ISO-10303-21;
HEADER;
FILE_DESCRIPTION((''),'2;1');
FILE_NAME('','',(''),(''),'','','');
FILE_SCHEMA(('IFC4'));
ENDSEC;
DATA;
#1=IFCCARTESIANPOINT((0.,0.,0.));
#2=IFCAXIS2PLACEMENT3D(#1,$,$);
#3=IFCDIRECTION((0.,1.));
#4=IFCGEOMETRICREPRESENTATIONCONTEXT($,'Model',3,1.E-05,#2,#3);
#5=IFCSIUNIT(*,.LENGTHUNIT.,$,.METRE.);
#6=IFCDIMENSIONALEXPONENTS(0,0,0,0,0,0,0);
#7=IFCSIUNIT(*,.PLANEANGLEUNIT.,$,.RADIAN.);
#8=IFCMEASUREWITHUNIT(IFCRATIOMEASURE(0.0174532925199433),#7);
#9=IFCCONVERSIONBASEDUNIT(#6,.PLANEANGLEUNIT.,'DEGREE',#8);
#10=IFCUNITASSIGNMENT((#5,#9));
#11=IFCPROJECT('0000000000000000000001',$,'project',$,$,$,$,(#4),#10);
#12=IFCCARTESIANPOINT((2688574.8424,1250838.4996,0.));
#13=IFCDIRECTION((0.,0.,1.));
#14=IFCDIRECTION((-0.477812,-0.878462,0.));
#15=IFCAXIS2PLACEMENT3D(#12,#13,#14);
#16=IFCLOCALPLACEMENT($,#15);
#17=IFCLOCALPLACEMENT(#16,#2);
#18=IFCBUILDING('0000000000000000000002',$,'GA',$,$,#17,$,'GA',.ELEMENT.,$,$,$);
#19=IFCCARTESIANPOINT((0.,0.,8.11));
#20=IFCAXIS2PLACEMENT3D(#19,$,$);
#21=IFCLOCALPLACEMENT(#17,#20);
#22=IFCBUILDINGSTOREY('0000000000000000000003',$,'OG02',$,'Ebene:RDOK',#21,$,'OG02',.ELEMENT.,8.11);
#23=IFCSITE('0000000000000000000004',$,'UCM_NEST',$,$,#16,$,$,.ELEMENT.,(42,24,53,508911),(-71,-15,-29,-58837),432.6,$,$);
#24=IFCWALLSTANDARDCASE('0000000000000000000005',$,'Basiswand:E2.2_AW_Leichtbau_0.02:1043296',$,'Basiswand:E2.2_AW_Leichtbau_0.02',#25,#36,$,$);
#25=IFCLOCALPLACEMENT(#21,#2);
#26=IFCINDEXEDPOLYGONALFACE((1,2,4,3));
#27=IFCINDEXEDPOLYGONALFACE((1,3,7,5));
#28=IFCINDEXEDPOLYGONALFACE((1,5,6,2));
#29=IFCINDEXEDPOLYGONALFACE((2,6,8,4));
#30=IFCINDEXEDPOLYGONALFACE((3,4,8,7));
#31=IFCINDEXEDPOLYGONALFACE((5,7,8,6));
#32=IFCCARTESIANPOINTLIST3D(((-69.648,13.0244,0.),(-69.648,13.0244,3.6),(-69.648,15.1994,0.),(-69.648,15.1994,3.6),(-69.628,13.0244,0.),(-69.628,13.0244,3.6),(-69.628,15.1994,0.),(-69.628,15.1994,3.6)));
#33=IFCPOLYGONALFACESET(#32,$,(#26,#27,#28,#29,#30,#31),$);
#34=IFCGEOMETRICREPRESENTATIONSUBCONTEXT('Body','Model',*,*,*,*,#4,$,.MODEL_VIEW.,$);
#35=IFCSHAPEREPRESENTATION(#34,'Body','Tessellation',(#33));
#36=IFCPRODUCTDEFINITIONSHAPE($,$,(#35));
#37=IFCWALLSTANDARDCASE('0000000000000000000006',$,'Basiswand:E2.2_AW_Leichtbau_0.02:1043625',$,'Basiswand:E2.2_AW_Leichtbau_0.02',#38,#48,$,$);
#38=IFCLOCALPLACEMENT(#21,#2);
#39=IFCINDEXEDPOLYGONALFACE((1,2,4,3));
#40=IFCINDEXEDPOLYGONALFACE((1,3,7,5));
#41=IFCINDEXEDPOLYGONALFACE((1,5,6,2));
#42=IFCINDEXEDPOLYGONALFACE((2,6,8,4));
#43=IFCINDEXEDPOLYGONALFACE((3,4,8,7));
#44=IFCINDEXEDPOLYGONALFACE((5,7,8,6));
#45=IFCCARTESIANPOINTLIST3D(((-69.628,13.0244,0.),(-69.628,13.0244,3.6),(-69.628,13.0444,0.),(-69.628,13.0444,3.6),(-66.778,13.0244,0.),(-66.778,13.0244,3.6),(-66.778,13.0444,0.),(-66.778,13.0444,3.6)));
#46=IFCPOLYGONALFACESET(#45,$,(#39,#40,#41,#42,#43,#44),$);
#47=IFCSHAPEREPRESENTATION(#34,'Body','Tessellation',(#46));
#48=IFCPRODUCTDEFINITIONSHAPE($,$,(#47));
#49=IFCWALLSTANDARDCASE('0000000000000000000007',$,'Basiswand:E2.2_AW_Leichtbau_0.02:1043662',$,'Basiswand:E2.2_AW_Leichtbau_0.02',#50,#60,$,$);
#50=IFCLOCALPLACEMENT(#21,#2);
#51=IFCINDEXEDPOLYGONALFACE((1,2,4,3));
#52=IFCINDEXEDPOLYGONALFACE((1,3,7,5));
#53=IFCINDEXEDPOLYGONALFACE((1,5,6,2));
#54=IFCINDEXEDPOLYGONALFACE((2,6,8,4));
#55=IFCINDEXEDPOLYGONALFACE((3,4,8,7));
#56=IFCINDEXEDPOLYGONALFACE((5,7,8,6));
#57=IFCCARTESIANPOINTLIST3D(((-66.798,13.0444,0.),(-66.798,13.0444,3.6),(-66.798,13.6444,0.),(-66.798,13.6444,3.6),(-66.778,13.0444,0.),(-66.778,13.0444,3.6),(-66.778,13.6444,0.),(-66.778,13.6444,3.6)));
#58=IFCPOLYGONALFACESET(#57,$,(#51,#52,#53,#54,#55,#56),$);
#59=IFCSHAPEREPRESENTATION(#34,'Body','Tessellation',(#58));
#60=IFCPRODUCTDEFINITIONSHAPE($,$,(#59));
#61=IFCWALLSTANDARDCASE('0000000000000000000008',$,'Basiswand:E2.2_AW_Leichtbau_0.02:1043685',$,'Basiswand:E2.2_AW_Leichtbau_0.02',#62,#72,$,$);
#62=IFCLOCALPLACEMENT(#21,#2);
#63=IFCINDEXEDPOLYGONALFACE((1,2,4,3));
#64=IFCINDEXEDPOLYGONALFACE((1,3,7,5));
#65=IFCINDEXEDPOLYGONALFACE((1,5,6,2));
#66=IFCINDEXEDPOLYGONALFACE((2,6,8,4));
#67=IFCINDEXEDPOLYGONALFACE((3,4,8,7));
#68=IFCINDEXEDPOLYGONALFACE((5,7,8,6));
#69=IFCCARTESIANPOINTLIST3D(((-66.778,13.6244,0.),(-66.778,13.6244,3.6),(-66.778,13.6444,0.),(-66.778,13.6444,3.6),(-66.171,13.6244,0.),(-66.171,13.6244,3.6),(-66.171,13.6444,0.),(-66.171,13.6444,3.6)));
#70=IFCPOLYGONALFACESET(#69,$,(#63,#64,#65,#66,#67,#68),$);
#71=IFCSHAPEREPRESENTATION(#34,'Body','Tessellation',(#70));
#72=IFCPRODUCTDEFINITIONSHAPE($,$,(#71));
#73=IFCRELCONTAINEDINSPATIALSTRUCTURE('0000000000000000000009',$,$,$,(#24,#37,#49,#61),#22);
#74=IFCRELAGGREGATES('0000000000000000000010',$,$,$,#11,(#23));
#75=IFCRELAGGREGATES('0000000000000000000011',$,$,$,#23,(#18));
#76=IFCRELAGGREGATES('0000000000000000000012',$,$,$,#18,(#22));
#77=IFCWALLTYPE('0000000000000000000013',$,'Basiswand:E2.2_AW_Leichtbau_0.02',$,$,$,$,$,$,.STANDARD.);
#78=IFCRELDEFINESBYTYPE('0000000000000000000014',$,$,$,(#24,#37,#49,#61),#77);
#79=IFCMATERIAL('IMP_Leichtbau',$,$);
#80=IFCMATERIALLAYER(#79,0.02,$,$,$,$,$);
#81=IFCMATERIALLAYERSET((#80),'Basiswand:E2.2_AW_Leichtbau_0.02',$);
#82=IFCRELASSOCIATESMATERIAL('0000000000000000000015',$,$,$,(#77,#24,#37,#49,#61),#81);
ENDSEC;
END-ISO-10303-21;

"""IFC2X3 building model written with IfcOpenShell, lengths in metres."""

from ifc_helpers import new_model, entity, si_unit, converted_unit, direction, frame, frame_2d, origin, place, context, subcontext, project, spatial, rectangle, extrude, material, layer, layer_set, layer_usage, type_object, element, save


model = new_model("IFC2X3")

# Units and contexts
model_context = context("Model", 3, precision=1e-05, world=origin(), true_north=direction((0.0, 1.0)))
body_context = subcontext(model_context, "Body", "Model", "MODEL_VIEW")
ifc_project = project(units=[si_unit("LENGTHUNIT", "METRE"), converted_unit("PLANEANGLEUNIT", "DEGREE", entity("IfcRatioMeasure", 0.0174532925199433), si_unit("PLANEANGLEUNIT", "RADIAN"), dimensions=[0, 0, 0, 0, 0, 0, 0])], contexts=[model_context])

# Site, building, storey
site_placement = place(None, frame((2688574.8424, 1250838.4996, 0.0), z_axis=(0.0, 0.0, 1.0), x_axis=(-0.477812, -0.878462, 0.0)))
site = spatial("IfcSite", under=ifc_project, at=site_placement, Name="UCM_NEST", CompositionType="ELEMENT", RefLatitude=(42, 24, 53, 508911), RefLongitude=(-71, -15, -29, -58837), RefElevation=432.6)
building_placement = place(site_placement, origin())
building = spatial("IfcBuilding", under=site, at=building_placement, Name="GA", LongName="GA", CompositionType="ELEMENT")
storey_placement = place(building_placement, frame((0.0, 0.0, 8.11)))
storey = spatial("IfcBuildingStorey", under=building, at=storey_placement, Name="OG02", ObjectType="Ebene:RDOK", LongName="OG02", CompositionType="ELEMENT", Elevation=8.11)

# Shared definitions
ifc_material_1 = material(Name="IMP_Leichtbau")

# Walls
ifc_layer_1 = layer(ifc_material_1, 0.02)
ifc_layer_set_1 = layer_set([ifc_layer_1], Name="Basiswand:E2.2_AW_Leichtbau_0.02")
wall_type_1 = type_object("IfcWallType", Name="Basiswand:E2.2_AW_Leichtbau_0.02", PredefinedType="STANDARD", material=ifc_layer_set_1)
ifc_layer_usage_1 = layer_usage(ifc_layer_set_1, "AXIS2", "NEGATIVE", 0.01)
wall_1_placement = place(storey_placement, frame((-69.638, 15.1994, 0.0), z_axis=(0.0, 0.0, 1.0), x_axis=(0.0, -1.0, 0.0)))
element("IfcWallStandardCase", 1, at=wall_1_placement, inside=storey, type_object=wall_type_1, material=ifc_layer_usage_1, Name="Basiswand:E2.2_AW_Leichtbau_0.02:1043296", ObjectType="Basiswand:E2.2_AW_Leichtbau_0.02", context=body_context, shape_type="SweptSolid", body=[
    extrude(rectangle(XDim=2.175, YDim=0.02, at=frame_2d((1.0875, 0.0), x_axis=(-1.0, 0.0))), origin(), (0.0, 0.0, 1.0), 3.6),
])
ifc_layer_usage_2 = layer_usage(ifc_layer_set_1, "AXIS2", "NEGATIVE", 0.01)
wall_2_placement = place(storey_placement, frame((-69.628, 13.0344, 0.0)))
element("IfcWallStandardCase", 2, at=wall_2_placement, inside=storey, type_object=wall_type_1, material=ifc_layer_usage_2, Name="Basiswand:E2.2_AW_Leichtbau_0.02:1043625", ObjectType="Basiswand:E2.2_AW_Leichtbau_0.02", context=body_context, shape_type="SweptSolid", body=[
    extrude(rectangle(XDim=2.85, YDim=0.02, at=frame_2d((1.425, 0.0), x_axis=(-1.0, 0.0))), origin(), (0.0, 0.0, 1.0), 3.6),
])
ifc_layer_usage_3 = layer_usage(ifc_layer_set_1, "AXIS2", "NEGATIVE", 0.01)
wall_3_placement = place(storey_placement, frame((-66.788, 13.0444, 0.0), z_axis=(0.0, 0.0, 1.0), x_axis=(0.0, 1.0, 0.0)))
element("IfcWallStandardCase", 3, at=wall_3_placement, inside=storey, type_object=wall_type_1, material=ifc_layer_usage_3, Name="Basiswand:E2.2_AW_Leichtbau_0.02:1043662", ObjectType="Basiswand:E2.2_AW_Leichtbau_0.02", context=body_context, shape_type="SweptSolid", body=[
    extrude(rectangle(XDim=0.6, YDim=0.02, at=frame_2d((0.3, 0.0), x_axis=(-1.0, 0.0))), origin(), (0.0, 0.0, 1.0), 3.6),
])
ifc_layer_usage_4 = layer_usage(ifc_layer_set_1, "AXIS2", "NEGATIVE", 0.01)
wall_4_placement = place(storey_placement, frame((-66.778, 13.6344, 0.0)))
element("IfcWallStandardCase", 4, at=wall_4_placement, inside=storey, type_object=wall_type_1, material=ifc_layer_usage_4, Name="Basiswand:E2.2_AW_Leichtbau_0.02:1043685", ObjectType="Basiswand:E2.2_AW_Leichtbau_0.02", context=body_context, shape_type="SweptSolid", body=[
    extrude(rectangle(XDim=0.607, YDim=0.02, at=frame_2d((0.3035, 0.0), x_axis=(-1.0, 0.0))), origin(), (0.0, 0.0, 1.0), 3.6),
])

save(model, "model.ifc")
